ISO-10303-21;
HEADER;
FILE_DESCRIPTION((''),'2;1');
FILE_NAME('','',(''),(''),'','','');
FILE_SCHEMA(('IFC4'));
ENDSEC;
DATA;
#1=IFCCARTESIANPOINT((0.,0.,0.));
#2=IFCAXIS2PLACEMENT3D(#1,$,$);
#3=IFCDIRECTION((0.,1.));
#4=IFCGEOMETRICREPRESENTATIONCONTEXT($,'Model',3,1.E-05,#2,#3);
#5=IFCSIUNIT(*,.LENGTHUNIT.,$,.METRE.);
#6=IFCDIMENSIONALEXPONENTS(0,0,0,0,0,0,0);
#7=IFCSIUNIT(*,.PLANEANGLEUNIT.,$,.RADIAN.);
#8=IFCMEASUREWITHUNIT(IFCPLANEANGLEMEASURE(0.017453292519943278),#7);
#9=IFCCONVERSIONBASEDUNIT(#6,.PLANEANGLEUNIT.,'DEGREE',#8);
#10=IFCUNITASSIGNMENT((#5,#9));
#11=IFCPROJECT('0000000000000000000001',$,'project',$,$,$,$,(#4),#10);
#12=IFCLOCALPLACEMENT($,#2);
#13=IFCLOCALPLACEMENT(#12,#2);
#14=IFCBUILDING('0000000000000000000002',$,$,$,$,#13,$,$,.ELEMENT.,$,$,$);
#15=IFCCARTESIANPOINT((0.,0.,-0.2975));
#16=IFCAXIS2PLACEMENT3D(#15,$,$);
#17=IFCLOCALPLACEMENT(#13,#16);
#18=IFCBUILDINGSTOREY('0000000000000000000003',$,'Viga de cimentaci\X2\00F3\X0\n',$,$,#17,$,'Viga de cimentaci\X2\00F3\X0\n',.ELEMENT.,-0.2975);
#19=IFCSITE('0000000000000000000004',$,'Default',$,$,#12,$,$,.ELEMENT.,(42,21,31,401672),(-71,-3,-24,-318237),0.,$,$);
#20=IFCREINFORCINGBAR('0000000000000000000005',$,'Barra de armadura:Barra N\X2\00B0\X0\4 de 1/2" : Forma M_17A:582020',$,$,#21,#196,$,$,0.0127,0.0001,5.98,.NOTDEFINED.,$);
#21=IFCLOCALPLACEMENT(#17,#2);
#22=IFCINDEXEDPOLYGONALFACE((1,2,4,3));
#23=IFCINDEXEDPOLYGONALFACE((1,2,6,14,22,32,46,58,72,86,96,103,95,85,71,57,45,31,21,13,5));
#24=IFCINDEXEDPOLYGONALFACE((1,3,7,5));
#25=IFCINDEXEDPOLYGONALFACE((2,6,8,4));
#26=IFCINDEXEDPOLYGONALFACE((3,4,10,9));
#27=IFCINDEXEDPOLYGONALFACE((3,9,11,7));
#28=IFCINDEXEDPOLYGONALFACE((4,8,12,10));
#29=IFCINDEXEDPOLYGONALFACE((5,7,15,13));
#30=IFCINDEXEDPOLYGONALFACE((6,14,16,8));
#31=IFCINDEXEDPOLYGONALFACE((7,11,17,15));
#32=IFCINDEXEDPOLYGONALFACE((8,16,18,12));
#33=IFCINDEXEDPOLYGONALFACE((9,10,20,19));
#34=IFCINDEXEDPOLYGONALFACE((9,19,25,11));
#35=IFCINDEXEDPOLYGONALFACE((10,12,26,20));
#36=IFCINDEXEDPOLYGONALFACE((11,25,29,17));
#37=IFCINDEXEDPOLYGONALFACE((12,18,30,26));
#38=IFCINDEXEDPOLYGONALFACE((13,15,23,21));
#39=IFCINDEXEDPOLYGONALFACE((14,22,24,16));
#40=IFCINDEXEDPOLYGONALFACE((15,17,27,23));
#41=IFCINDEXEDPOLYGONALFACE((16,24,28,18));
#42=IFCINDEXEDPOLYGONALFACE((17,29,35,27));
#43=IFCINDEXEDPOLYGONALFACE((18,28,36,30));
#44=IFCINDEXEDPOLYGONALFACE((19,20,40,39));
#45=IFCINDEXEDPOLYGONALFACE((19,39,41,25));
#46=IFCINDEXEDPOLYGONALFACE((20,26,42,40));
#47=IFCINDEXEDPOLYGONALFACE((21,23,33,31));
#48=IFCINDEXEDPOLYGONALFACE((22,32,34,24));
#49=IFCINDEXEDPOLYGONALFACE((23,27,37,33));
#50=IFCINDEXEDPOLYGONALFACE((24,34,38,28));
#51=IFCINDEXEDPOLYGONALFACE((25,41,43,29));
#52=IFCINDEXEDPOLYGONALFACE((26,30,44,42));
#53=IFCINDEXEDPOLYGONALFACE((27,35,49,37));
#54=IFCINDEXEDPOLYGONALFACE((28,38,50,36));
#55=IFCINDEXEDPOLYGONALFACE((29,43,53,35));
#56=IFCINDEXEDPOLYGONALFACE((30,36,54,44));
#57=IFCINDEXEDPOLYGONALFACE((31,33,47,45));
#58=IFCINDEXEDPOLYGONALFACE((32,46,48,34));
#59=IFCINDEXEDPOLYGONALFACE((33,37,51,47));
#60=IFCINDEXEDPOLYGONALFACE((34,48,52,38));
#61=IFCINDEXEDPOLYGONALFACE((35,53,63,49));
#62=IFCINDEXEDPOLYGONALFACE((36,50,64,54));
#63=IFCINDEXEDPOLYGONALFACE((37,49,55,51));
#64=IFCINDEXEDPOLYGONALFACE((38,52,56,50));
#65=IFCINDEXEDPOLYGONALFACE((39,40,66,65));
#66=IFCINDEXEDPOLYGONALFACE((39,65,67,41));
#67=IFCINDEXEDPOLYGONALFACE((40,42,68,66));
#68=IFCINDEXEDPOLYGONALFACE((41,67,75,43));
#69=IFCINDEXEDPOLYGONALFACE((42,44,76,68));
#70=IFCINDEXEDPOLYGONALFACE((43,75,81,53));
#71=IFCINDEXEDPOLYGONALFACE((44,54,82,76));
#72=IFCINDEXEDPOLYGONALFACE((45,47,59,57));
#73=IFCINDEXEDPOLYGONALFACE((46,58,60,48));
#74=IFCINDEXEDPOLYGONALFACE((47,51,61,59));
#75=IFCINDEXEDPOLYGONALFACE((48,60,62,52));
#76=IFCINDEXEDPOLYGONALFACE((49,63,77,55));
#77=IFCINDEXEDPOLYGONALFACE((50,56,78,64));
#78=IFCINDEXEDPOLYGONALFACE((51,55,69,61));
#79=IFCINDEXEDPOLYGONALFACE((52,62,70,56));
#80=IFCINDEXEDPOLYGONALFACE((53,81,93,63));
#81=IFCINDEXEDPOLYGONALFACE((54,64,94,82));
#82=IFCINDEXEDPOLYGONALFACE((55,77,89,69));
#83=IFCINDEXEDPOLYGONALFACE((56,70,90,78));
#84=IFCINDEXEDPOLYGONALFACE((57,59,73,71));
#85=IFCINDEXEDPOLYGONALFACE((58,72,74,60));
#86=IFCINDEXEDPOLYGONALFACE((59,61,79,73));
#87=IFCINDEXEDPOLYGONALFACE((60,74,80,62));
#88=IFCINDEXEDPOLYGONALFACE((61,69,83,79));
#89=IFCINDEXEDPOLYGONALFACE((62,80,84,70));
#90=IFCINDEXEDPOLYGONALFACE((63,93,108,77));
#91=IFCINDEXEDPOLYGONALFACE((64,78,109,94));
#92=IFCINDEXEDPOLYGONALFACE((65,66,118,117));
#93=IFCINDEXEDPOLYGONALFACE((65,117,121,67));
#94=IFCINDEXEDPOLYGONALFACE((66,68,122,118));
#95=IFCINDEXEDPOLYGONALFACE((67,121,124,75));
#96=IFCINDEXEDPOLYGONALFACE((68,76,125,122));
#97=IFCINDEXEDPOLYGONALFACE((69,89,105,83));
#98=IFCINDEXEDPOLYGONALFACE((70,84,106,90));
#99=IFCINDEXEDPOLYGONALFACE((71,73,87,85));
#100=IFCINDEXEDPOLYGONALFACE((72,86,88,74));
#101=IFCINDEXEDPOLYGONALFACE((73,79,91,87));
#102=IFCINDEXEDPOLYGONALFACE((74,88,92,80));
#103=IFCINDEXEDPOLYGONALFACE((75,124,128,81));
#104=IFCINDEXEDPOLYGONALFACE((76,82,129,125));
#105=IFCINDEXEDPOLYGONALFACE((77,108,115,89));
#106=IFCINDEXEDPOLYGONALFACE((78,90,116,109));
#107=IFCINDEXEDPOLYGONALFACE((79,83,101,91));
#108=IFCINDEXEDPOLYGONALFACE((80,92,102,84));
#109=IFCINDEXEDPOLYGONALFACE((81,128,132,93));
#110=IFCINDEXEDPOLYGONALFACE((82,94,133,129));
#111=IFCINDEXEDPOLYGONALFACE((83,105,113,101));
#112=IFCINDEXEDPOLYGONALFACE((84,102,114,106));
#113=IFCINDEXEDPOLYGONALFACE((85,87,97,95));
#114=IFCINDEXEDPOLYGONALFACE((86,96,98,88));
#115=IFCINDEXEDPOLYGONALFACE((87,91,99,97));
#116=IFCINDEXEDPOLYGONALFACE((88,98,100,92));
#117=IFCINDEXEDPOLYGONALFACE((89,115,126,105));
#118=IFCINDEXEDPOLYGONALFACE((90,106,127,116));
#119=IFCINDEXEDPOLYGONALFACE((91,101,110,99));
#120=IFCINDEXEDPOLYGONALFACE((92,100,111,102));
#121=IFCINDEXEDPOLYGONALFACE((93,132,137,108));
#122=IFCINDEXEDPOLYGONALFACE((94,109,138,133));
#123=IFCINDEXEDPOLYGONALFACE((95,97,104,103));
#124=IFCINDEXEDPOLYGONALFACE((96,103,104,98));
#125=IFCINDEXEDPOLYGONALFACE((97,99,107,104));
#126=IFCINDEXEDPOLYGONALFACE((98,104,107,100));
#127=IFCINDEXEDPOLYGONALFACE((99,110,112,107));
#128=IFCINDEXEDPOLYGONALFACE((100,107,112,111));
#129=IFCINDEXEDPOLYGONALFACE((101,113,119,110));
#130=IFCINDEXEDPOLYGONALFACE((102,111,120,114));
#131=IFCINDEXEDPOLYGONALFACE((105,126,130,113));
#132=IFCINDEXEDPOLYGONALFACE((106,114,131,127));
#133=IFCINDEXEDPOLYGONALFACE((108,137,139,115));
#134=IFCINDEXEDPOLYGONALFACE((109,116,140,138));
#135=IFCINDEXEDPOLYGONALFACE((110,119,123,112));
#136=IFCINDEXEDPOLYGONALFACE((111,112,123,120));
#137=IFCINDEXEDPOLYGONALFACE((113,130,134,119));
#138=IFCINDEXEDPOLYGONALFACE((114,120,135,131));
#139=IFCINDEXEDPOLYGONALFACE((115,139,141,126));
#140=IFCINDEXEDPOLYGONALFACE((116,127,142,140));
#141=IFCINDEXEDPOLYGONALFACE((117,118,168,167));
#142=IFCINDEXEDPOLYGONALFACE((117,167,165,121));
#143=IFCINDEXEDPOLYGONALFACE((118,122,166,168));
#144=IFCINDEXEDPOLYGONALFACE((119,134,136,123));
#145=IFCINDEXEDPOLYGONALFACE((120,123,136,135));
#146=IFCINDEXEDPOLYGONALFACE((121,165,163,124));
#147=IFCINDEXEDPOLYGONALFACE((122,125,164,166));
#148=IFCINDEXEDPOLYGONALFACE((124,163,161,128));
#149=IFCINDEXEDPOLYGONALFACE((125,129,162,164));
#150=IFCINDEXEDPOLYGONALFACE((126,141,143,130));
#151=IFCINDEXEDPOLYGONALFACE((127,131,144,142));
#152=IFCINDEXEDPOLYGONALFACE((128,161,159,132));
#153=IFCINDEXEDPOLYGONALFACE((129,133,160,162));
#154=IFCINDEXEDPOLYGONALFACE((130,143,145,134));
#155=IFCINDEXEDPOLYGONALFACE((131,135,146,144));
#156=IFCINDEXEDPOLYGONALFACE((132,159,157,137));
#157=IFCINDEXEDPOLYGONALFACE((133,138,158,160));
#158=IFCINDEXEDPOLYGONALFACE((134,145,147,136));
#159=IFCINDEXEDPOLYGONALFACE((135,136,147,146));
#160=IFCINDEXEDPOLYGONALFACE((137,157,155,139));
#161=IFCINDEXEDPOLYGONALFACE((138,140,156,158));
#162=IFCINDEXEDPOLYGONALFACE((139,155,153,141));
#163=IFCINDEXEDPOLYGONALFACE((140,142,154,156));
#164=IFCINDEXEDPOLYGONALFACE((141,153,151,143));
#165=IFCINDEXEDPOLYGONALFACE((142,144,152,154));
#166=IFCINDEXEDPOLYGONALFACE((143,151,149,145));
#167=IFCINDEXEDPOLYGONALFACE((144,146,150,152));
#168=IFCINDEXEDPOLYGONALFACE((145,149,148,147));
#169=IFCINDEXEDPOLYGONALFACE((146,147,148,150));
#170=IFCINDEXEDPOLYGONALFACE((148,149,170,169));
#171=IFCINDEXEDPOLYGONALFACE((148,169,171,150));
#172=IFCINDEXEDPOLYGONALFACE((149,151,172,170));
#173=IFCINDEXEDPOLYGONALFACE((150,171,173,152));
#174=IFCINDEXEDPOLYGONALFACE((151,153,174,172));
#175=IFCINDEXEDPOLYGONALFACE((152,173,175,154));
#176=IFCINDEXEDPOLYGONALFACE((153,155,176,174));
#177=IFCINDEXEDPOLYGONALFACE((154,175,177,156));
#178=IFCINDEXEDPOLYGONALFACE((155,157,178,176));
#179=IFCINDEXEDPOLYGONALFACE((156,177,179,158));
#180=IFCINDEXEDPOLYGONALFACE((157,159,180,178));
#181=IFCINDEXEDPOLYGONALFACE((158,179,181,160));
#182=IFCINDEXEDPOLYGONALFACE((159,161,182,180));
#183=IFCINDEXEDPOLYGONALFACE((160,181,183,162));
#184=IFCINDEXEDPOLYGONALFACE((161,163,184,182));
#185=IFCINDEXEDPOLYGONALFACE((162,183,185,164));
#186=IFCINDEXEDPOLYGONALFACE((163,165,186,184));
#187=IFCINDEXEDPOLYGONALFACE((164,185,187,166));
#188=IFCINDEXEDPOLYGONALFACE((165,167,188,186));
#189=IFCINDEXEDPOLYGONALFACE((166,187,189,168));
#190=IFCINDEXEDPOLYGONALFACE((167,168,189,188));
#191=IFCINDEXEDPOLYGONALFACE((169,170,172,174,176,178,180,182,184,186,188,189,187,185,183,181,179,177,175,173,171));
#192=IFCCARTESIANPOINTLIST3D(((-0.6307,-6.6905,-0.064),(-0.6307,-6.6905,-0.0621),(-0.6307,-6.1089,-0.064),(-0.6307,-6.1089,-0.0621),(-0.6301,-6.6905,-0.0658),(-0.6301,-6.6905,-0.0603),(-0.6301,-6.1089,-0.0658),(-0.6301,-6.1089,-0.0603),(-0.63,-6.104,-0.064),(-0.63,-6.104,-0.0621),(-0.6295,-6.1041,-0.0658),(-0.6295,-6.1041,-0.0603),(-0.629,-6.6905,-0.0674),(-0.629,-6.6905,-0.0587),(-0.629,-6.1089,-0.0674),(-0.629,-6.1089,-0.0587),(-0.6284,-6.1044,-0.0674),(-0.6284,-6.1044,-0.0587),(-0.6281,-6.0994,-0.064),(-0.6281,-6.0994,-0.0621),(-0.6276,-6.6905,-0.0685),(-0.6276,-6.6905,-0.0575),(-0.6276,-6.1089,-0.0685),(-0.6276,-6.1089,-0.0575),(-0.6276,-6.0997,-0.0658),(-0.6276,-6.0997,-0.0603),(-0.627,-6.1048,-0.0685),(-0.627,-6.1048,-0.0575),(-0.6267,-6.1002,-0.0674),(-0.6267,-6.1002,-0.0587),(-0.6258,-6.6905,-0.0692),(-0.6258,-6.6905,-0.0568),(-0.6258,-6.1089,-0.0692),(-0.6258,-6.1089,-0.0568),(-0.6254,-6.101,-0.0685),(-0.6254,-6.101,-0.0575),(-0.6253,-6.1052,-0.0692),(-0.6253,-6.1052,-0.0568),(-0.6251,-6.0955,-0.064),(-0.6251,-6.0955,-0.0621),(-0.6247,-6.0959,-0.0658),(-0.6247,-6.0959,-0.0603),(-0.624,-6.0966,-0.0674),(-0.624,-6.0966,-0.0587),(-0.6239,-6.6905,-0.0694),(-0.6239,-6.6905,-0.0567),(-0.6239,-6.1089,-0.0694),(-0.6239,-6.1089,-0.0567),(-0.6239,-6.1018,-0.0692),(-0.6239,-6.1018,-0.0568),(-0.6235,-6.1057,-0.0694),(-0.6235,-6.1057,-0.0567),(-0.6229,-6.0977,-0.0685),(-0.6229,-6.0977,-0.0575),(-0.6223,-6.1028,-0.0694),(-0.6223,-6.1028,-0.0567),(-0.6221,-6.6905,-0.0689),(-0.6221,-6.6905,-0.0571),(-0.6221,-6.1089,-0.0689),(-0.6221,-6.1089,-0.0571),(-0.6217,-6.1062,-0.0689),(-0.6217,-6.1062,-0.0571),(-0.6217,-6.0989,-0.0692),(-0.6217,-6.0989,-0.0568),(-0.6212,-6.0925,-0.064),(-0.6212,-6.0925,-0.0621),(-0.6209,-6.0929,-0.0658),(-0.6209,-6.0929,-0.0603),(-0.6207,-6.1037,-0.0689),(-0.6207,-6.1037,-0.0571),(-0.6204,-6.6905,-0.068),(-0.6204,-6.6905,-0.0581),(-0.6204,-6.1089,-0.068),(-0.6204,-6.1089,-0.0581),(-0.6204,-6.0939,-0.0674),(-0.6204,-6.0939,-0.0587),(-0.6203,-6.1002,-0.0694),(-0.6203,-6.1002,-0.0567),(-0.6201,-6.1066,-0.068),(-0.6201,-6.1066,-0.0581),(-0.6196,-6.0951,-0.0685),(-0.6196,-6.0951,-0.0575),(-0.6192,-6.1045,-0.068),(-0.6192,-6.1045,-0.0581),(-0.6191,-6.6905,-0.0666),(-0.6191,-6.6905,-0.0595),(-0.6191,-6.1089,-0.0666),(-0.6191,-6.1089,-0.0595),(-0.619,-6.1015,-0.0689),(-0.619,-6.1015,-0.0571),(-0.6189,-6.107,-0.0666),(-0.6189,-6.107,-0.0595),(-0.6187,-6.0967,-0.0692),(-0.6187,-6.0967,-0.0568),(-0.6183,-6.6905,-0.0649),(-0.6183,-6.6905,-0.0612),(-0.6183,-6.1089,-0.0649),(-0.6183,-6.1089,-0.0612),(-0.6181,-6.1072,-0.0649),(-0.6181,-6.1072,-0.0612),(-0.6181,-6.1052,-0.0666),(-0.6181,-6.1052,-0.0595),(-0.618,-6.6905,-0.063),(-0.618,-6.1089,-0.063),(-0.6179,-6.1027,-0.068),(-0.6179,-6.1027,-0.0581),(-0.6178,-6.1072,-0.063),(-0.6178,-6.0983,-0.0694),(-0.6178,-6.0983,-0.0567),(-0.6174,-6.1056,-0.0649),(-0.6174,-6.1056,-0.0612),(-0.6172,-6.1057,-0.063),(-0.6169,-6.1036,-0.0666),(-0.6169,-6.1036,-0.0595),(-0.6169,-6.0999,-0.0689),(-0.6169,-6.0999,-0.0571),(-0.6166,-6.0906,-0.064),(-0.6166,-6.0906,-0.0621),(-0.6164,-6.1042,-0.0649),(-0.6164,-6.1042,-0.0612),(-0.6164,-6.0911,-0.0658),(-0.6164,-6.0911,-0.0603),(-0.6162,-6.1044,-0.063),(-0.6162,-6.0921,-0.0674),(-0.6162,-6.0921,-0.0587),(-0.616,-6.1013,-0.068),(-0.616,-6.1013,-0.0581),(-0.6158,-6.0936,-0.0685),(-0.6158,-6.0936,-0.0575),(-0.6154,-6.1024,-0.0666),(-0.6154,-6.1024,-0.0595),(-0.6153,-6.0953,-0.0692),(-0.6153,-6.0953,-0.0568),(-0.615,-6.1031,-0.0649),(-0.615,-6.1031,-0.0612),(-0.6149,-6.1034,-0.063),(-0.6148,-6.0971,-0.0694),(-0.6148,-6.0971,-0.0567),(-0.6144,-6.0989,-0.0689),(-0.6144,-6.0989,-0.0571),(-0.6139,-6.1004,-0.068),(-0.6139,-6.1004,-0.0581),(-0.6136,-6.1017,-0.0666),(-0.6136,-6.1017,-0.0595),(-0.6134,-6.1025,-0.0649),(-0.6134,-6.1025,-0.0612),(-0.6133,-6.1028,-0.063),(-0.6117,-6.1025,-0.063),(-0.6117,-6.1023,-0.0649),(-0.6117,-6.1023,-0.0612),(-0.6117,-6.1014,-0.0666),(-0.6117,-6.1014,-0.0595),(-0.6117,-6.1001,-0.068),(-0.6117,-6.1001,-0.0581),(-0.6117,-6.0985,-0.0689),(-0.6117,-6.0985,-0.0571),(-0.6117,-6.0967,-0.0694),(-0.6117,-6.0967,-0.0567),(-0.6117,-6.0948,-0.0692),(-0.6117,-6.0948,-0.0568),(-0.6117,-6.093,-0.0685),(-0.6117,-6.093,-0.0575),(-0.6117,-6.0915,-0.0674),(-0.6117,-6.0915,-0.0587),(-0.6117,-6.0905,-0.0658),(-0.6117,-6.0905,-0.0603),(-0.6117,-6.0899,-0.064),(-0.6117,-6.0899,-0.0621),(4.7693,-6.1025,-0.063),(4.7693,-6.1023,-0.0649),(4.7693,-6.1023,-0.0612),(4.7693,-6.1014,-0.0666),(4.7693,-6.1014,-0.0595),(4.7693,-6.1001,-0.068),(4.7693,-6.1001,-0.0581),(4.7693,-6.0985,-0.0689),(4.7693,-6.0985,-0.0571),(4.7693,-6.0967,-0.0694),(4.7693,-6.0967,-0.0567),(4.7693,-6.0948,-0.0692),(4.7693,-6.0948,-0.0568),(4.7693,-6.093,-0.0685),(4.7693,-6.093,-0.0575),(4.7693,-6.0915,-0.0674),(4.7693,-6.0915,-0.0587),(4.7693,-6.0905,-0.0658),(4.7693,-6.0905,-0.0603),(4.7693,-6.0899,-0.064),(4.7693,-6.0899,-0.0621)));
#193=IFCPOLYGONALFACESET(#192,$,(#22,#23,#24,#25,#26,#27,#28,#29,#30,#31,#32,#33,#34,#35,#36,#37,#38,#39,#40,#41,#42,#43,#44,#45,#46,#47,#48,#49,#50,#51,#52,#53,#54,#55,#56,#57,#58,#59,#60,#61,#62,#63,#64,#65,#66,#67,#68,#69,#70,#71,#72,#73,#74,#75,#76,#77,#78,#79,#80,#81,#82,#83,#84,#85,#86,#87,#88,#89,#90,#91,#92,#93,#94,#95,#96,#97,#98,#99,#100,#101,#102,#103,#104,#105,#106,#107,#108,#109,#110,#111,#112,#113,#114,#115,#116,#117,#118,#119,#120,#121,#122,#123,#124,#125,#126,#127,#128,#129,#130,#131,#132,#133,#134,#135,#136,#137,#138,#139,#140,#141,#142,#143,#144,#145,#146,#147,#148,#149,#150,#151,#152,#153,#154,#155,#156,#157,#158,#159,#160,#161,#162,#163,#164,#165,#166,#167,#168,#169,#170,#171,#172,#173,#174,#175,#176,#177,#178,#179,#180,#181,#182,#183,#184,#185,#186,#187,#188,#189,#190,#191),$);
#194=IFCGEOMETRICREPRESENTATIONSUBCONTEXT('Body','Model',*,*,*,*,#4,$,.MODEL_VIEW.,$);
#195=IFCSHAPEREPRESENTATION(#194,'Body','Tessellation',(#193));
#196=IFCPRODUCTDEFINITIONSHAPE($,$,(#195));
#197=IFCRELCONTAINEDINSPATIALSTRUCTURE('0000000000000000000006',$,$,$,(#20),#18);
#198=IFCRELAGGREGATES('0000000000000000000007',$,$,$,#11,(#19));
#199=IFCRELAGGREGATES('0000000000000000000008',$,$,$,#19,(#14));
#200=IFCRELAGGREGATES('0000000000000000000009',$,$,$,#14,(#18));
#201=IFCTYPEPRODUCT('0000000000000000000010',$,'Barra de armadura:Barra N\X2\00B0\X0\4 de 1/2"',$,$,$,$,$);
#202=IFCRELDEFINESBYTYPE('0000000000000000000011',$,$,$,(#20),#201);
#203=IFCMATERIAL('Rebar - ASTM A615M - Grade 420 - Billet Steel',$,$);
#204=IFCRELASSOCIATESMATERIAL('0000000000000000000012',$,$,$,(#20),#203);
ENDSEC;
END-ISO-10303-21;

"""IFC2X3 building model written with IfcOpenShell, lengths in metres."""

from ifc_helpers import new_model, entity, si_unit, converted_unit, direction, frame, origin, place, context, subcontext, project, spatial, material, type_object, element, save


model = new_model("IFC2X3")

# Units and contexts
model_context = context("Model", 3, precision=1e-05, world=origin(), true_north=direction((0.0, 1.0)))
body_context = subcontext(model_context, "Body", "Model", "MODEL_VIEW")
ifc_project = project(units=[si_unit("LENGTHUNIT", "METRE"), converted_unit("PLANEANGLEUNIT", "DEGREE", entity("IfcPlaneAngleMeasure", 0.017453292519943278), si_unit("PLANEANGLEUNIT", "RADIAN"), dimensions=[0, 0, 0, 0, 0, 0, 0])], contexts=[model_context])

# Site, building, storey
site_placement = place(None, origin())
site = spatial("IfcSite", under=ifc_project, at=site_placement, Name="Default", CompositionType="ELEMENT", RefLatitude=(42, 21, 31, 401672), RefLongitude=(-71, -3, -24, -318237), RefElevation=0.0)
building_placement = place(site_placement, origin())
building = spatial("IfcBuilding", under=site, at=building_placement, CompositionType="ELEMENT")
storey_placement = place(building_placement, frame((0.0, 0.0, -0.2975)))
storey = spatial("IfcBuildingStorey", under=building, at=storey_placement, Name="Viga de cimentación", LongName="Viga de cimentación", CompositionType="ELEMENT", Elevation=-0.2975)

# Reinforcing bar
ifc_material = material(Name="Rebar - ASTM A615M - Grade 420 - Billet Steel")
type_product_1 = type_object("IfcTypeProduct", Name="Barra de armadura:Barra N°4 de 1/2\"")
reinforcing_bar_1_placement = place(storey_placement, origin())
element("IfcReinforcingBar", 1, at=reinforcing_bar_1_placement, inside=storey, type_object=type_product_1, material=ifc_material, Name="Barra de armadura:Barra N°4 de 1/2\" : Forma M_17A:582020", BarLength=5.98, BarRole="NOTDEFINED", CrossSectionArea=0.0001, NominalDiameter=0.0127, context=body_context, shape_type="AdvancedSweptSolid", body=[
    entity("IfcSweptDiskSolid", entity("IfcCompositeCurve", [entity("IfcCompositeCurveSegment", "CONTINUOUS", True, entity("IfcPolyline", [entity("IfcCartesianPoint", [-0.6244, -6.6905, -0.063]), entity("IfcCartesianPoint", [-0.6244, -6.1089, -0.063])])), entity("IfcCompositeCurveSegment", "CONTINUOUS", True, entity("IfcTrimmedCurve", entity("IfcCircle", entity("IfcAxis2Placement3D", entity("IfcCartesianPoint", [-0.6117, -6.1089, -0.063]), entity("IfcDirection", [0.0, 0.0, -1.0]), entity("IfcDirection", [0.0, 1.0, 0.0])), 0.0127), [entity("IfcParameterValue", 270.0)], [entity("IfcParameterValue", 360.0)], True, "PARAMETER")), entity("IfcCompositeCurveSegment", "CONTINUOUS", True, entity("IfcPolyline", [entity("IfcCartesianPoint", [-0.6117, -6.0962, -0.063]), entity("IfcCartesianPoint", [4.7693, -6.0962, -0.063])]))], False), 0.0063, None, 0.0, 92.0),
])

save(model, "model.ifc")
